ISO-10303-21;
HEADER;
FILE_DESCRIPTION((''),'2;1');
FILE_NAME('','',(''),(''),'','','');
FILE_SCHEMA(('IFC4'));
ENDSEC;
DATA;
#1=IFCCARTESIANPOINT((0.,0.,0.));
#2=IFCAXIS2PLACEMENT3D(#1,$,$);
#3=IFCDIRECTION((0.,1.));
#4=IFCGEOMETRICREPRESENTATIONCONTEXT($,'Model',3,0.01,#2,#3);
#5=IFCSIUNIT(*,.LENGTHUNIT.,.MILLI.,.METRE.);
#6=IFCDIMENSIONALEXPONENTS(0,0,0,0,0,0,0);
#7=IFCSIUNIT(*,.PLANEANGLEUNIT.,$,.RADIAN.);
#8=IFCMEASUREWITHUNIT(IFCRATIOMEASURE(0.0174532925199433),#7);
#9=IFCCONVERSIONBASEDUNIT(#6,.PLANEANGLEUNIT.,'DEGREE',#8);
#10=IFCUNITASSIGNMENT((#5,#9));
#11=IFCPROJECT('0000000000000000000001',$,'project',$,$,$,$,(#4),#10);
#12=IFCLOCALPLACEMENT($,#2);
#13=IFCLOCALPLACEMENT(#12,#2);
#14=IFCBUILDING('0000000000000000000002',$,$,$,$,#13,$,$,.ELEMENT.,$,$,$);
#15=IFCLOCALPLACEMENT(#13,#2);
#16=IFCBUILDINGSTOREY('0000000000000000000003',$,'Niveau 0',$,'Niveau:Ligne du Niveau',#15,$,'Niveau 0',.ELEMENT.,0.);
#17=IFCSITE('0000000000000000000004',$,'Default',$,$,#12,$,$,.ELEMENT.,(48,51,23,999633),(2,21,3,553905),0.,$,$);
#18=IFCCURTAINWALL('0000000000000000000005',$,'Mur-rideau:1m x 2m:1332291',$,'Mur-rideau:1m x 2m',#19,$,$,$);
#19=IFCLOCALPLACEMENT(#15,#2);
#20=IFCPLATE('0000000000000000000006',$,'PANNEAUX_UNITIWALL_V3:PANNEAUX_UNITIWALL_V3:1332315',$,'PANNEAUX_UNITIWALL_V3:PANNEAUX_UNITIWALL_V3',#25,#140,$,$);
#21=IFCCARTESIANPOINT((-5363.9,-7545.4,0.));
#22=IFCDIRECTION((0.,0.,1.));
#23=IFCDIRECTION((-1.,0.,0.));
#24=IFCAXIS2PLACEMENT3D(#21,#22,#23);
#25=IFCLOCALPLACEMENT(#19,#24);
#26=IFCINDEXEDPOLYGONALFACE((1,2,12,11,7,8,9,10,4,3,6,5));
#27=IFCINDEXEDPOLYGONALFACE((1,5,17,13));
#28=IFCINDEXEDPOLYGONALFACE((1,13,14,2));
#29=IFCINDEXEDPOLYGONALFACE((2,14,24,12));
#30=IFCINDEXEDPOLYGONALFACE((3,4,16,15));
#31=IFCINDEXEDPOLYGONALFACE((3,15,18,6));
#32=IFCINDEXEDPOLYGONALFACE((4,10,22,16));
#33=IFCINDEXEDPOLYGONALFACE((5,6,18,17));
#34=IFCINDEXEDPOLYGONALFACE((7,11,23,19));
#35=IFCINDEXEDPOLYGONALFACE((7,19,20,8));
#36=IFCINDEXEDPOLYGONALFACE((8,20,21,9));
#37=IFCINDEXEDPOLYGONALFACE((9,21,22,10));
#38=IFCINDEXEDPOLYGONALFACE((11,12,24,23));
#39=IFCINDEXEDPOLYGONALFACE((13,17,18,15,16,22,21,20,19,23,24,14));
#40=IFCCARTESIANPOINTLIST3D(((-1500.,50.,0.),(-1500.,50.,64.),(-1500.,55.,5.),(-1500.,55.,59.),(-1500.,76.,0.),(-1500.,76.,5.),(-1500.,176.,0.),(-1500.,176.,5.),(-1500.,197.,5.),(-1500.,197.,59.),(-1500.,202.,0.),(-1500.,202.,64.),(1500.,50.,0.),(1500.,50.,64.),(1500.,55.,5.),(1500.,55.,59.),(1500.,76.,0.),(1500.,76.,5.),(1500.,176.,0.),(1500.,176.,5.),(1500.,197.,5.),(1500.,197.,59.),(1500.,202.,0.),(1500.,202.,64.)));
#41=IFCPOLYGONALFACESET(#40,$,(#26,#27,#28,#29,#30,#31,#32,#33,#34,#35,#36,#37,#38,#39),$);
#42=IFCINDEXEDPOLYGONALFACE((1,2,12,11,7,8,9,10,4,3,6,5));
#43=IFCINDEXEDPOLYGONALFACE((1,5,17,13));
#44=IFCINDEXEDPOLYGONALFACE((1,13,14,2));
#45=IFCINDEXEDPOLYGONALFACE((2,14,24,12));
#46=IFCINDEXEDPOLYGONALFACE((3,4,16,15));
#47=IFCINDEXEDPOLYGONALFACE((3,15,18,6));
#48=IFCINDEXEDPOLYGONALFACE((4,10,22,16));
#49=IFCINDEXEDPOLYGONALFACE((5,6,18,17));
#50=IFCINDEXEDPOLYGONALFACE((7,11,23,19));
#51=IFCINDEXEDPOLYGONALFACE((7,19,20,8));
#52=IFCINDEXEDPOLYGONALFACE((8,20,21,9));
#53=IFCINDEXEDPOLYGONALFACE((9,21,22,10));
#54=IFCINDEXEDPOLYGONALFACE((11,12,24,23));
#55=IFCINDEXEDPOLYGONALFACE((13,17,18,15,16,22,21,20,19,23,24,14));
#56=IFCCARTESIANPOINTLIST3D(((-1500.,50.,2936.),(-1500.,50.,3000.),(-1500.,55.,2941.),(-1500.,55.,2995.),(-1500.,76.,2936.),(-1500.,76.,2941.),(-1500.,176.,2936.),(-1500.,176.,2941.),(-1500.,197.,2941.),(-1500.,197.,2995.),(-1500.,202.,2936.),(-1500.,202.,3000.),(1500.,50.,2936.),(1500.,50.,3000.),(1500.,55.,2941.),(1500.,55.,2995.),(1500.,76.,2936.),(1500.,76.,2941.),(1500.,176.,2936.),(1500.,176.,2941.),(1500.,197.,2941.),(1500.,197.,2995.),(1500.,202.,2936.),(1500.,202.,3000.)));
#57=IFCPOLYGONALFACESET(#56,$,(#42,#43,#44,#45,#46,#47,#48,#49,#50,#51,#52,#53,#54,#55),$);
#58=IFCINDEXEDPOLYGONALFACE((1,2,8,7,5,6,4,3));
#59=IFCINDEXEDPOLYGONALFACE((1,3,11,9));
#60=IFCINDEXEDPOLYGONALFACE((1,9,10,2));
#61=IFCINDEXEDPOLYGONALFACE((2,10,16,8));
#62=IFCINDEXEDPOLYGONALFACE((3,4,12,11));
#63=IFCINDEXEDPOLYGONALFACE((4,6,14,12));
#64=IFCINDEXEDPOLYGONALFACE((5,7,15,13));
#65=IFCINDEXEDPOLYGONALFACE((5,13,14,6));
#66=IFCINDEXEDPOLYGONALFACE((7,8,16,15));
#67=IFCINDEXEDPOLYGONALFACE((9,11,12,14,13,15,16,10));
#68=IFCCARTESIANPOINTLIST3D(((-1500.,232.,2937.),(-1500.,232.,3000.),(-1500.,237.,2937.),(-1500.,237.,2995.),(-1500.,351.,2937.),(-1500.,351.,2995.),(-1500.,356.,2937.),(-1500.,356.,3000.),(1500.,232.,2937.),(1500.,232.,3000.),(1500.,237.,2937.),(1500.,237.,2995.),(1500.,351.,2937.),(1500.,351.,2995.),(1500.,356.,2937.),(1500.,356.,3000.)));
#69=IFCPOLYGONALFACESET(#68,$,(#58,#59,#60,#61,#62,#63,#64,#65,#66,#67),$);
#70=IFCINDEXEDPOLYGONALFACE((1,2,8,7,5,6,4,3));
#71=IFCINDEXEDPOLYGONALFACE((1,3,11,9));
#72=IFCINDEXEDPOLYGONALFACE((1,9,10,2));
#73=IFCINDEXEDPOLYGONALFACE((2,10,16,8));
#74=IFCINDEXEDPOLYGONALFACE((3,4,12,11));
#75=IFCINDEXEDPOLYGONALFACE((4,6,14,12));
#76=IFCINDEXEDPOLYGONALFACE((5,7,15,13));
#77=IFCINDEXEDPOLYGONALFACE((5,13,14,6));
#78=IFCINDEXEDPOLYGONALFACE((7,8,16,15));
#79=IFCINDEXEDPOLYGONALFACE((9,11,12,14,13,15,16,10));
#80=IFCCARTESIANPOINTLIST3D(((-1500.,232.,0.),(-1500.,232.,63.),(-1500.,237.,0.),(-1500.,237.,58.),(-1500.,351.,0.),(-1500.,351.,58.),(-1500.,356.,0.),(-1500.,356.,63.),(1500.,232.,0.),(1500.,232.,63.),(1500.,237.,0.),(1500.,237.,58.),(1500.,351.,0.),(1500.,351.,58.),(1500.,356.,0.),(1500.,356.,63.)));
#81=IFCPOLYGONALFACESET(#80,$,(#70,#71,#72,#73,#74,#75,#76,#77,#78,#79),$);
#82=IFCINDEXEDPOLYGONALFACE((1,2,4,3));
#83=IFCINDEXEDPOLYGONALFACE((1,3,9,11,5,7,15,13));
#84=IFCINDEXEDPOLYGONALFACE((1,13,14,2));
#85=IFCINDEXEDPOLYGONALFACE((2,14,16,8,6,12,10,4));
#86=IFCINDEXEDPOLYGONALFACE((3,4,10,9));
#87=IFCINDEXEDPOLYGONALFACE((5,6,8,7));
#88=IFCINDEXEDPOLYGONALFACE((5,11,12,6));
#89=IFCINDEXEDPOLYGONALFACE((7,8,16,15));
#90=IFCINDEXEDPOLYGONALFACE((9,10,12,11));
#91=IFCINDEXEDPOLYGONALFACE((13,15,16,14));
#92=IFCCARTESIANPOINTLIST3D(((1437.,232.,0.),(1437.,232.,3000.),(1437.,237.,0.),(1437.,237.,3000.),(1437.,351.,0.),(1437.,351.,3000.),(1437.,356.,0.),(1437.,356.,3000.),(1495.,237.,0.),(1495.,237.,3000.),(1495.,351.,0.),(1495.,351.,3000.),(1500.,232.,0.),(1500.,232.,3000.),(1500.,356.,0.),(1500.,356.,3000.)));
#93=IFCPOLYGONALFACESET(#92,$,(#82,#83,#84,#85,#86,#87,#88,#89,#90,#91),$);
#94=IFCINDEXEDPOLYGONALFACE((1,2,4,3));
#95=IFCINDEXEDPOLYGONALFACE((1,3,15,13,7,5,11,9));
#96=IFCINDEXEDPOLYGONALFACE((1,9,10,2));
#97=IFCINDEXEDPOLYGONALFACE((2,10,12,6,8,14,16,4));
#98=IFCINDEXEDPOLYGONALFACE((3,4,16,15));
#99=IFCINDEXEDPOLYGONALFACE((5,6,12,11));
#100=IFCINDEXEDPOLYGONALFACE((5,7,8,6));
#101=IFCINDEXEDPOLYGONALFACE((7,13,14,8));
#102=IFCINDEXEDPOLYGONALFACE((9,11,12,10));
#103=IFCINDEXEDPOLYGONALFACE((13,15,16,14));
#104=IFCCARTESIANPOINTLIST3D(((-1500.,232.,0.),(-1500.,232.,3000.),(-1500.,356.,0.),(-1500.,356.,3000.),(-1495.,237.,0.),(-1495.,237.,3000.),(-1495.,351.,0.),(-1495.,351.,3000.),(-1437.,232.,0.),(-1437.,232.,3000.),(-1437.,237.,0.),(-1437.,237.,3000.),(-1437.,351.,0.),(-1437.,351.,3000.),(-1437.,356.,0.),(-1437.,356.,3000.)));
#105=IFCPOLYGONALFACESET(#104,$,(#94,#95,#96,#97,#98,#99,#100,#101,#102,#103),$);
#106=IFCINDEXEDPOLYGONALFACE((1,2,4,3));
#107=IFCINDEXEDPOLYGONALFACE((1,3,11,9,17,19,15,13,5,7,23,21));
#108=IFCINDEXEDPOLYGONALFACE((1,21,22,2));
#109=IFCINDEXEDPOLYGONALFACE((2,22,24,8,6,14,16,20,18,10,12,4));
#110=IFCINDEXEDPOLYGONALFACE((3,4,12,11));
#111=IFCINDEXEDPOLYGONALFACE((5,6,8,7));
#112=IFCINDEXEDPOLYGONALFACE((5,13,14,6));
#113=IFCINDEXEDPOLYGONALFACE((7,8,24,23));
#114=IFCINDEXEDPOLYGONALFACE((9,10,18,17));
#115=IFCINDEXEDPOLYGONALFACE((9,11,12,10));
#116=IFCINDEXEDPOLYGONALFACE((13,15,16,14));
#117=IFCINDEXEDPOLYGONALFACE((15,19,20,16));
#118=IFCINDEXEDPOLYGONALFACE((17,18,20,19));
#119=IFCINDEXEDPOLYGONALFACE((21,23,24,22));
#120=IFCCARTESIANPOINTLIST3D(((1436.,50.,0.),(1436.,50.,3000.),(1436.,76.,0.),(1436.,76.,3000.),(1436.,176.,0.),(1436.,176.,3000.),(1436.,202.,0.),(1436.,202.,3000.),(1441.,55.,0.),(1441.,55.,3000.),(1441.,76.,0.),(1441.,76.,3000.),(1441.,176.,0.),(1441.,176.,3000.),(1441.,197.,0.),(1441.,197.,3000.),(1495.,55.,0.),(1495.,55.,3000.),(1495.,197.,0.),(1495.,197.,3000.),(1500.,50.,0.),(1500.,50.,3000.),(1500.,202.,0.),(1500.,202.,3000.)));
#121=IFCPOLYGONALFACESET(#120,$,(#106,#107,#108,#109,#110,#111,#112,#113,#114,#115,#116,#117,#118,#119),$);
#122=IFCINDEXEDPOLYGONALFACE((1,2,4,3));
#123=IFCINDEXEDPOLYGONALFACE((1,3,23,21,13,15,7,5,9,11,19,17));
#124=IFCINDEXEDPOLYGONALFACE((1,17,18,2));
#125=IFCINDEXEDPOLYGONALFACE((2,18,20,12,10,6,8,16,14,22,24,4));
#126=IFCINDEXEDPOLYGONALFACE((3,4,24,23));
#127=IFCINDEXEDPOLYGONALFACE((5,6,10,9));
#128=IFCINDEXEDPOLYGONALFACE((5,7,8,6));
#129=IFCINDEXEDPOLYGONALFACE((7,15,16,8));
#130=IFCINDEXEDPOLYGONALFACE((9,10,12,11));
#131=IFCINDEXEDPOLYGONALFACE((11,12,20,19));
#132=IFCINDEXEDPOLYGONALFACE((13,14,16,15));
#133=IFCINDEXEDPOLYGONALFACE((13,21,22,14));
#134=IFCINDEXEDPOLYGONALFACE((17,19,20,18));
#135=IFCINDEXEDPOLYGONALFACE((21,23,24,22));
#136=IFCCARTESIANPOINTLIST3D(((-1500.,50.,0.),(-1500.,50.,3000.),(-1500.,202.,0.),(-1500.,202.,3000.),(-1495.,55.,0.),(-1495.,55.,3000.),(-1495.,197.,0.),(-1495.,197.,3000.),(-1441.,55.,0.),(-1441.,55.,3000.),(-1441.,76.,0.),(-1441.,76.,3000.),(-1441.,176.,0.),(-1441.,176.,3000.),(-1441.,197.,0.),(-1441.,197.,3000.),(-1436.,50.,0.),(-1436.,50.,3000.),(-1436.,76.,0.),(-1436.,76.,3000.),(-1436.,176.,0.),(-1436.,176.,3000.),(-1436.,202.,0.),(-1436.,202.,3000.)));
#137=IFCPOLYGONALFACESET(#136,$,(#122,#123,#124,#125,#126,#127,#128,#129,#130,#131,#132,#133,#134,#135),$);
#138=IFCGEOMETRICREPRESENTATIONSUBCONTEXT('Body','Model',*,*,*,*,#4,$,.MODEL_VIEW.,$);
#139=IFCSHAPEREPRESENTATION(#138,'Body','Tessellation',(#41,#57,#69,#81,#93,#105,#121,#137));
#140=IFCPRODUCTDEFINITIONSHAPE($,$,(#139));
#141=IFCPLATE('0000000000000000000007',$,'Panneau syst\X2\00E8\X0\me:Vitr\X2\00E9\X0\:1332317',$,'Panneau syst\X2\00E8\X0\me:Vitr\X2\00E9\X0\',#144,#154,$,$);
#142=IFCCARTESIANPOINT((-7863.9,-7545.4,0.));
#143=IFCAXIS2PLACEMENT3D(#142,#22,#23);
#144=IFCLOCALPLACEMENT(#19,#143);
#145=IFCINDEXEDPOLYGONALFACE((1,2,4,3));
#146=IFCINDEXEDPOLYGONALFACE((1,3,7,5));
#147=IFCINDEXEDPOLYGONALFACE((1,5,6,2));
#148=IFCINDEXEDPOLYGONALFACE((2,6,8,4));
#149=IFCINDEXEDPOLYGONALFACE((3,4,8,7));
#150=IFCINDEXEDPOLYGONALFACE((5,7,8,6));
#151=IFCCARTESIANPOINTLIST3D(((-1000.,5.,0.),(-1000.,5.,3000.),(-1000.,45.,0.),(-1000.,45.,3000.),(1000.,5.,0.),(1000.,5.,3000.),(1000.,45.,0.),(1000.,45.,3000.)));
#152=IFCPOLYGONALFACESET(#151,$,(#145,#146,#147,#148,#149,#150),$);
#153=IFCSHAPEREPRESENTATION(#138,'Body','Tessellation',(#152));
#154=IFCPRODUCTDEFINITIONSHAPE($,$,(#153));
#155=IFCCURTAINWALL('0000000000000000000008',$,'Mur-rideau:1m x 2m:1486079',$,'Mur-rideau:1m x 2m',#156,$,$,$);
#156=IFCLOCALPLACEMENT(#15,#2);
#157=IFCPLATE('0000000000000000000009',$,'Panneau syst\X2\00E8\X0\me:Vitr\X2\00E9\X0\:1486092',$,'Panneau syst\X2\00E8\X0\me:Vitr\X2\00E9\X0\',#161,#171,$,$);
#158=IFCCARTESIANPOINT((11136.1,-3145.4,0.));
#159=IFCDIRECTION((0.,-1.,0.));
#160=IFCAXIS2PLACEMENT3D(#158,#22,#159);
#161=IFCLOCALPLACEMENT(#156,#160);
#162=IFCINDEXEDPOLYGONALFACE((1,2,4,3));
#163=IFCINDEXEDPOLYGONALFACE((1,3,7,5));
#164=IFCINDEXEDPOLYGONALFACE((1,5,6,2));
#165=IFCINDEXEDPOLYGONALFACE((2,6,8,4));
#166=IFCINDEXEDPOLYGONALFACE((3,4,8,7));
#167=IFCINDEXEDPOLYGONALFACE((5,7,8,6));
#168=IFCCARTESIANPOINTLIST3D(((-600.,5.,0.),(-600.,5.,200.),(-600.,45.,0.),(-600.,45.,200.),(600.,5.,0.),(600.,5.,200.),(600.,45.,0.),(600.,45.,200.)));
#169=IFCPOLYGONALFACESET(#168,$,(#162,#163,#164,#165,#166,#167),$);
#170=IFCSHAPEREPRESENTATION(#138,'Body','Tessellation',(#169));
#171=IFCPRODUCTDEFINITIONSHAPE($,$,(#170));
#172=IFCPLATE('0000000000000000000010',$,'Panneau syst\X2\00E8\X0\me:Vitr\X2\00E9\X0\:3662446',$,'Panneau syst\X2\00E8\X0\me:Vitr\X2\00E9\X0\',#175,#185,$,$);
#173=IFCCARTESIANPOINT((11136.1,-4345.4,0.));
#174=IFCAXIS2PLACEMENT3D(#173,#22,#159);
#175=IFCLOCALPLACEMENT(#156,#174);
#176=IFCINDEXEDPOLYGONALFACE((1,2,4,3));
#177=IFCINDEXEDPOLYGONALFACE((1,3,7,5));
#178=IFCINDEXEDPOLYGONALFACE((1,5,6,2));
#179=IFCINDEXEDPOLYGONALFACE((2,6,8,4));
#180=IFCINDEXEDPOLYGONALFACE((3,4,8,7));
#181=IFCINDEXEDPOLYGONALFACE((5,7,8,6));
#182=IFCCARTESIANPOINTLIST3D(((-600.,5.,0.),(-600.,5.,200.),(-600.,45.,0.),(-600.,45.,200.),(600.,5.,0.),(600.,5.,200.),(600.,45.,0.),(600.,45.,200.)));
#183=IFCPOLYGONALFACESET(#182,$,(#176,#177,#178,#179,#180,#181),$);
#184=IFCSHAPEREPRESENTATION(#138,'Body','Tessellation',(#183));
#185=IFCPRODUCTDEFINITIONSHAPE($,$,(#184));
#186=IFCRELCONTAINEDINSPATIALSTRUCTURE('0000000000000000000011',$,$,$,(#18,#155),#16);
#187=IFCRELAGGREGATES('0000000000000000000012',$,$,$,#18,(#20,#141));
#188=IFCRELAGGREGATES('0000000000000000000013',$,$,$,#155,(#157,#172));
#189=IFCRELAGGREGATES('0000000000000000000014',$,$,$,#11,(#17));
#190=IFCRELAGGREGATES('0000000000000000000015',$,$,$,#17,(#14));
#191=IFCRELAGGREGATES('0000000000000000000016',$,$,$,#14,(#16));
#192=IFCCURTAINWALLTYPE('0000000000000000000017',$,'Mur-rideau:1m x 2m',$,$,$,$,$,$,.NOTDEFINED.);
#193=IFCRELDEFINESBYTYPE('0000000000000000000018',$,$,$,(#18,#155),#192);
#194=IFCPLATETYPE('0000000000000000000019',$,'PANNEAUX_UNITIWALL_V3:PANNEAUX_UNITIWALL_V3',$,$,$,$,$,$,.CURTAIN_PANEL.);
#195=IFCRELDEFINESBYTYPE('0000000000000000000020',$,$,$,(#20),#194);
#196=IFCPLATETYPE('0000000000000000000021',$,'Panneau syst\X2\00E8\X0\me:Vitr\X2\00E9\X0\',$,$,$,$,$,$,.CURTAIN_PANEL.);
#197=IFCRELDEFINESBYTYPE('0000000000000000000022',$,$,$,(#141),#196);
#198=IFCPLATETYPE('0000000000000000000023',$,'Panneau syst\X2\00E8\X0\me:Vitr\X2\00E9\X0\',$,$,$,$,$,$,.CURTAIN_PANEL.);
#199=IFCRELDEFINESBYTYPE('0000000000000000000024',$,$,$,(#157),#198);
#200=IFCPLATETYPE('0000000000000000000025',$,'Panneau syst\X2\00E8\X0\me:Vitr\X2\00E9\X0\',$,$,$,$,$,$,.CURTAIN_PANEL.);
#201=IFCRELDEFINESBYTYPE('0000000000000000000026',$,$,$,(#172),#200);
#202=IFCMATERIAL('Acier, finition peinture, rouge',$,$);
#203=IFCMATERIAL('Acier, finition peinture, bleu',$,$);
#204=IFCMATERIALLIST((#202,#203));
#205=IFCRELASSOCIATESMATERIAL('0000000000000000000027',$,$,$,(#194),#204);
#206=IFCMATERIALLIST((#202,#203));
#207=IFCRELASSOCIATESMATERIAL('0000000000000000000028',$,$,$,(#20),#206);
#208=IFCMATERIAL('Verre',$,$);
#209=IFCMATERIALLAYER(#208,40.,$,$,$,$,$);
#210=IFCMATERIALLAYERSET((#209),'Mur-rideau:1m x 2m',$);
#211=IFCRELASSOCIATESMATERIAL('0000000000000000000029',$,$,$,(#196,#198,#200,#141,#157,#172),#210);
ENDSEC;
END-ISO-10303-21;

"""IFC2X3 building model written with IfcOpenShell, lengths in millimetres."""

from ifc_helpers import new_model, entity, si_unit, converted_unit, direction, frame, frame_2d, origin, place, context, subcontext, project, spatial, polyline, rectangle, outline, extrude, source, transform, mapped, material, material_list, layer, layer_set, layer_usage, type_object, type_shapes, element, aggregate, save


model = new_model("IFC2X3")

# Units and contexts
model_context = context("Model", 3, precision=0.01, world=origin(), true_north=direction((0.0, 1.0)))
body_context = subcontext(model_context, "Body", "Model", "MODEL_VIEW")
ifc_project = project(units=[si_unit("LENGTHUNIT", "METRE", prefix="MILLI"), converted_unit("PLANEANGLEUNIT", "DEGREE", entity("IfcRatioMeasure", 0.0174532925199433), si_unit("PLANEANGLEUNIT", "RADIAN"), dimensions=[0, 0, 0, 0, 0, 0, 0])], contexts=[model_context])

# Site, building, storey
site_placement = place(None, origin())
site = spatial("IfcSite", under=ifc_project, at=site_placement, Name="Default", CompositionType="ELEMENT", RefLatitude=(48, 51, 23, 999633), RefLongitude=(2, 21, 3, 553905), RefElevation=0.0)
building_placement = place(site_placement, origin())
building = spatial("IfcBuilding", under=site, at=building_placement, CompositionType="ELEMENT")
storey_placement = place(building_placement, origin())
storey = spatial("IfcBuildingStorey", under=building, at=storey_placement, Name="Niveau 0", ObjectType="Niveau:Ligne du Niveau", LongName="Niveau 0", CompositionType="ELEMENT", Elevation=0.0)

# Curtain walls, plates
curtain_wall_type_1 = type_object("IfcCurtainWallType", Name="Mur-rideau:1m x 2m", PredefinedType="NOTDEFINED")
curtain_wall_1_placement = place(storey_placement, origin())
curtain_wall_1 = element("IfcCurtainWall", 1, at=curtain_wall_1_placement, inside=storey, type_object=curtain_wall_type_1, Name="Mur-rideau:1m x 2m:1332291", ObjectType="Mur-rideau:1m x 2m")
ifc_material_1 = material(Name="Acier, finition peinture, bleu")
ifc_material_2 = material(Name="Acier, finition peinture, rouge")
ifc_material_list_1 = material_list([ifc_material_2, ifc_material_1])
plate_type_1 = type_object("IfcPlateType", Name="PANNEAUX_UNITIWALL_V3:PANNEAUX_UNITIWALL_V3", PredefinedType="CURTAIN_PANEL", material=ifc_material_list_1)
shared_shape_1 = source(origin(), body_context, "Body", "SweptSolid", [
    extrude(outline(polyline([(-41.8, -76.0), (22.2, -76.0), (22.2, -50.0), (17.2, -50.0), (17.2, -71.0), (-36.8, -71.0), (-36.8, 71.0), (17.2, 71.0), (17.2, 50.0), (22.2, 50.0), (22.2, 76.0), (-41.8, 76.0), (-41.8, -76.0)])), frame((-1500.0, 126.0, 22.2), z_axis=(1.0, 0.0, 0.0), x_axis=(0.0, 0.0, -1.0)), (0.0, 0.0, 1.0), 3000.0),
    extrude(outline(polyline([(-41.8, -76.0), (22.2, -76.0), (22.2, -50.0), (17.2, -50.0), (17.2, -71.0), (-36.8, -71.0), (-36.8, 71.0), (17.2, 71.0), (17.2, 50.0), (22.2, 50.0), (22.2, 76.0), (-41.8, 76.0), (-41.8, -76.0)])), frame((-1500.0, 126.0, 2958.2), z_axis=(1.0, 0.0, 0.0), x_axis=(0.0, 0.0, -1.0)), (0.0, 0.0, 1.0), 3000.0),
    extrude(outline(polyline([(-62.0, -32.8), (62.0, -32.8), (62.0, 30.2), (57.0, 30.2), (57.0, -27.8), (-57.0, -27.8), (-57.0, 30.2), (-62.0, 30.2), (-62.0, -32.8)])), frame((-1500.0, 294.0, 2967.3), z_axis=(1.0, 0.0, 0.0), x_axis=(0.0, -1.0, 0.0)), (0.0, 0.0, 1.0), 3000.0),
    extrude(outline(polyline([(-62.0, -32.8), (62.0, -32.8), (62.0, 30.2), (57.0, 30.2), (57.0, -27.8), (-57.0, -27.8), (-57.0, 30.2), (-62.0, 30.2), (-62.0, -32.8)])), frame((-1500.0, 294.0, 30.3), z_axis=(1.0, 0.0, 0.0), x_axis=(0.0, -1.0, 0.0)), (0.0, 0.0, 1.0), 3000.0),
    extrude(outline(polyline([(-62.0, -32.8), (62.0, -32.8), (62.0, 30.2), (57.0, 30.2), (57.0, -27.8), (-57.0, -27.8), (-57.0, 30.2), (-62.0, 30.2), (-62.0, -32.8)])), frame((1467.3, 294.0, 0.0), z_axis=(0.0, 0.0, 1.0), x_axis=(0.0, 1.0, 0.0)), (0.0, 0.0, 1.0), 3000.0),
    extrude(outline(polyline([(-32.8, -62.0), (30.2, -62.0), (30.2, -57.0), (-27.8, -57.0), (-27.8, 57.0), (30.2, 57.0), (30.2, 62.0), (-32.8, 62.0), (-32.8, -62.0)])), frame((-1467.3, 294.0, 0.0)), (0.0, 0.0, 1.0), 3000.0),
    extrude(outline(polyline([(-76.0, -41.8), (76.0, -41.8), (76.0, 22.2), (50.0, 22.2), (50.0, 17.2), (71.0, 17.2), (71.0, -36.8), (-71.0, -36.8), (-71.0, 17.2), (-50.0, 17.2), (-50.0, 22.2), (-76.0, 22.2), (-76.0, -41.8)])), frame((1458.2, 126.0, 0.0), z_axis=(0.0, 0.0, 1.0), x_axis=(0.0, 1.0, 0.0)), (0.0, 0.0, 1.0), 3000.0),
    extrude(outline(polyline([(-76.0, -41.8), (76.0, -41.8), (76.0, 22.2), (50.0, 22.2), (50.0, 17.2), (71.0, 17.2), (71.0, -36.8), (-71.0, -36.8), (-71.0, 17.2), (-50.0, 17.2), (-50.0, 22.2), (-76.0, 22.2), (-76.0, -41.8)])), frame((-1458.2, 126.0, 0.0), z_axis=(0.0, 0.0, 1.0), x_axis=(0.0, -1.0, 0.0)), (0.0, 0.0, 1.0), 3000.0),
])
type_shapes(plate_type_1, [shared_shape_1])
ifc_material_list_2 = material_list([ifc_material_2, ifc_material_1])
plate_1_placement = place(curtain_wall_1_placement, frame((-5363.9, -7545.4, 0.0), z_axis=(0.0, 0.0, 1.0), x_axis=(-1.0, 0.0, 0.0)))
plate_1 = element("IfcPlate", 2, at=plate_1_placement, type_object=plate_type_1, material=ifc_material_list_2, Name="PANNEAUX_UNITIWALL_V3:PANNEAUX_UNITIWALL_V3:1332315", ObjectType="PANNEAUX_UNITIWALL_V3:PANNEAUX_UNITIWALL_V3", context=body_context, shape_type="MappedRepresentation", body=[
    mapped(shared_shape_1, transform((0.0, 0.0, 0.0), scale=1.0)),
])
ifc_material_3 = material(Name="Verre")
ifc_layer_1 = layer(ifc_material_3, 40.0)
ifc_layer_set_1 = layer_set([ifc_layer_1], Name="Mur-rideau:1m x 2m")
ifc_layer_usage_1 = layer_usage(ifc_layer_set_1, "AXIS3", "POSITIVE", 0.1)
plate_type_2 = type_object("IfcPlateType", Name="Panneau système:Vitré", PredefinedType="CURTAIN_PANEL", material=ifc_layer_set_1)
shared_shape_2 = source(origin(), body_context, "Body", "SweptSolid", [
    extrude(rectangle(XDim=40.0, YDim=2000.0, at=frame_2d((0.0, 0.0), x_axis=(1.0, 0.0))), frame((0.0, 25.0, 0.0), z_axis=(0.0, 0.0, 1.0), x_axis=(0.0, 1.0, 0.0)), (0.0, 0.0, 1.0), 3000.0),
])
type_shapes(plate_type_2, [shared_shape_2])
plate_2_placement = place(curtain_wall_1_placement, frame((-7863.9, -7545.4, 0.0), z_axis=(0.0, 0.0, 1.0), x_axis=(-1.0, 0.0, 0.0)))
plate_2 = element("IfcPlate", 3, at=plate_2_placement, type_object=plate_type_2, material=ifc_layer_usage_1, Name="Panneau système:Vitré:1332317", ObjectType="Panneau système:Vitré", context=body_context, shape_type="MappedRepresentation", body=[
    mapped(shared_shape_2, transform((0.0, 0.0, 0.0), scale=1.0)),
])
aggregate(curtain_wall_1, [plate_1, plate_2])
curtain_wall_2_placement = place(storey_placement, origin())
curtain_wall_2 = element("IfcCurtainWall", 4, at=curtain_wall_2_placement, inside=storey, type_object=curtain_wall_type_1, Name="Mur-rideau:1m x 2m:1486079", ObjectType="Mur-rideau:1m x 2m")
ifc_layer_usage_2 = layer_usage(ifc_layer_set_1, "AXIS3", "POSITIVE", 0.1)
plate_type_3 = type_object("IfcPlateType", Name="Panneau système:Vitré", PredefinedType="CURTAIN_PANEL", material=ifc_layer_set_1)
shared_shape_3 = source(origin(), body_context, "Body", "SweptSolid", [
    extrude(rectangle(XDim=200.0, YDim=1200.0, at=frame_2d((0.0, -166.7), x_axis=(1.0, 0.0))), frame((166.7, 5.0, 100.0), z_axis=(0.0, 1.0, 0.0), x_axis=(0.0, 0.0, 1.0)), (0.0, 0.0, 1.0), 40.0),
])
type_shapes(plate_type_3, [shared_shape_3])
plate_3_placement = place(curtain_wall_2_placement, frame((11136.1, -3145.4, 0.0), z_axis=(0.0, 0.0, 1.0), x_axis=(0.0, -1.0, 0.0)))
plate_3 = element("IfcPlate", 5, at=plate_3_placement, type_object=plate_type_3, material=ifc_layer_usage_2, Name="Panneau système:Vitré:1486092", ObjectType="Panneau système:Vitré", context=body_context, shape_type="MappedRepresentation", body=[
    mapped(shared_shape_3, transform((0.0, 0.0, 0.0), scale=1.0)),
])
ifc_layer_usage_3 = layer_usage(ifc_layer_set_1, "AXIS3", "POSITIVE", 0.1)
plate_type_4 = type_object("IfcPlateType", Name="Panneau système:Vitré", PredefinedType="CURTAIN_PANEL", material=ifc_layer_set_1)
shared_shape_4 = source(origin(), body_context, "Body", "SweptSolid", [
    extrude(rectangle(XDim=40.0, YDim=1200.0, at=frame_2d((0.0, 0.0), x_axis=(1.0, 0.0))), frame((0.0, 25.0, 0.0), z_axis=(0.0, 0.0, 1.0), x_axis=(0.0, 1.0, 0.0)), (0.0, 0.0, 1.0), 200.0),
])
type_shapes(plate_type_4, [shared_shape_4])
plate_4_placement = place(curtain_wall_2_placement, frame((11136.1, -4345.4, 0.0), z_axis=(0.0, 0.0, 1.0), x_axis=(0.0, -1.0, 0.0)))
plate_4 = element("IfcPlate", 6, at=plate_4_placement, type_object=plate_type_4, material=ifc_layer_usage_3, Name="Panneau système:Vitré:3662446", ObjectType="Panneau système:Vitré", context=body_context, shape_type="MappedRepresentation", body=[
    mapped(shared_shape_4, transform((0.0, 0.0, 0.0), scale=1.0)),
])
aggregate(curtain_wall_2, [plate_3, plate_4])

save(model, "model.ifc")
